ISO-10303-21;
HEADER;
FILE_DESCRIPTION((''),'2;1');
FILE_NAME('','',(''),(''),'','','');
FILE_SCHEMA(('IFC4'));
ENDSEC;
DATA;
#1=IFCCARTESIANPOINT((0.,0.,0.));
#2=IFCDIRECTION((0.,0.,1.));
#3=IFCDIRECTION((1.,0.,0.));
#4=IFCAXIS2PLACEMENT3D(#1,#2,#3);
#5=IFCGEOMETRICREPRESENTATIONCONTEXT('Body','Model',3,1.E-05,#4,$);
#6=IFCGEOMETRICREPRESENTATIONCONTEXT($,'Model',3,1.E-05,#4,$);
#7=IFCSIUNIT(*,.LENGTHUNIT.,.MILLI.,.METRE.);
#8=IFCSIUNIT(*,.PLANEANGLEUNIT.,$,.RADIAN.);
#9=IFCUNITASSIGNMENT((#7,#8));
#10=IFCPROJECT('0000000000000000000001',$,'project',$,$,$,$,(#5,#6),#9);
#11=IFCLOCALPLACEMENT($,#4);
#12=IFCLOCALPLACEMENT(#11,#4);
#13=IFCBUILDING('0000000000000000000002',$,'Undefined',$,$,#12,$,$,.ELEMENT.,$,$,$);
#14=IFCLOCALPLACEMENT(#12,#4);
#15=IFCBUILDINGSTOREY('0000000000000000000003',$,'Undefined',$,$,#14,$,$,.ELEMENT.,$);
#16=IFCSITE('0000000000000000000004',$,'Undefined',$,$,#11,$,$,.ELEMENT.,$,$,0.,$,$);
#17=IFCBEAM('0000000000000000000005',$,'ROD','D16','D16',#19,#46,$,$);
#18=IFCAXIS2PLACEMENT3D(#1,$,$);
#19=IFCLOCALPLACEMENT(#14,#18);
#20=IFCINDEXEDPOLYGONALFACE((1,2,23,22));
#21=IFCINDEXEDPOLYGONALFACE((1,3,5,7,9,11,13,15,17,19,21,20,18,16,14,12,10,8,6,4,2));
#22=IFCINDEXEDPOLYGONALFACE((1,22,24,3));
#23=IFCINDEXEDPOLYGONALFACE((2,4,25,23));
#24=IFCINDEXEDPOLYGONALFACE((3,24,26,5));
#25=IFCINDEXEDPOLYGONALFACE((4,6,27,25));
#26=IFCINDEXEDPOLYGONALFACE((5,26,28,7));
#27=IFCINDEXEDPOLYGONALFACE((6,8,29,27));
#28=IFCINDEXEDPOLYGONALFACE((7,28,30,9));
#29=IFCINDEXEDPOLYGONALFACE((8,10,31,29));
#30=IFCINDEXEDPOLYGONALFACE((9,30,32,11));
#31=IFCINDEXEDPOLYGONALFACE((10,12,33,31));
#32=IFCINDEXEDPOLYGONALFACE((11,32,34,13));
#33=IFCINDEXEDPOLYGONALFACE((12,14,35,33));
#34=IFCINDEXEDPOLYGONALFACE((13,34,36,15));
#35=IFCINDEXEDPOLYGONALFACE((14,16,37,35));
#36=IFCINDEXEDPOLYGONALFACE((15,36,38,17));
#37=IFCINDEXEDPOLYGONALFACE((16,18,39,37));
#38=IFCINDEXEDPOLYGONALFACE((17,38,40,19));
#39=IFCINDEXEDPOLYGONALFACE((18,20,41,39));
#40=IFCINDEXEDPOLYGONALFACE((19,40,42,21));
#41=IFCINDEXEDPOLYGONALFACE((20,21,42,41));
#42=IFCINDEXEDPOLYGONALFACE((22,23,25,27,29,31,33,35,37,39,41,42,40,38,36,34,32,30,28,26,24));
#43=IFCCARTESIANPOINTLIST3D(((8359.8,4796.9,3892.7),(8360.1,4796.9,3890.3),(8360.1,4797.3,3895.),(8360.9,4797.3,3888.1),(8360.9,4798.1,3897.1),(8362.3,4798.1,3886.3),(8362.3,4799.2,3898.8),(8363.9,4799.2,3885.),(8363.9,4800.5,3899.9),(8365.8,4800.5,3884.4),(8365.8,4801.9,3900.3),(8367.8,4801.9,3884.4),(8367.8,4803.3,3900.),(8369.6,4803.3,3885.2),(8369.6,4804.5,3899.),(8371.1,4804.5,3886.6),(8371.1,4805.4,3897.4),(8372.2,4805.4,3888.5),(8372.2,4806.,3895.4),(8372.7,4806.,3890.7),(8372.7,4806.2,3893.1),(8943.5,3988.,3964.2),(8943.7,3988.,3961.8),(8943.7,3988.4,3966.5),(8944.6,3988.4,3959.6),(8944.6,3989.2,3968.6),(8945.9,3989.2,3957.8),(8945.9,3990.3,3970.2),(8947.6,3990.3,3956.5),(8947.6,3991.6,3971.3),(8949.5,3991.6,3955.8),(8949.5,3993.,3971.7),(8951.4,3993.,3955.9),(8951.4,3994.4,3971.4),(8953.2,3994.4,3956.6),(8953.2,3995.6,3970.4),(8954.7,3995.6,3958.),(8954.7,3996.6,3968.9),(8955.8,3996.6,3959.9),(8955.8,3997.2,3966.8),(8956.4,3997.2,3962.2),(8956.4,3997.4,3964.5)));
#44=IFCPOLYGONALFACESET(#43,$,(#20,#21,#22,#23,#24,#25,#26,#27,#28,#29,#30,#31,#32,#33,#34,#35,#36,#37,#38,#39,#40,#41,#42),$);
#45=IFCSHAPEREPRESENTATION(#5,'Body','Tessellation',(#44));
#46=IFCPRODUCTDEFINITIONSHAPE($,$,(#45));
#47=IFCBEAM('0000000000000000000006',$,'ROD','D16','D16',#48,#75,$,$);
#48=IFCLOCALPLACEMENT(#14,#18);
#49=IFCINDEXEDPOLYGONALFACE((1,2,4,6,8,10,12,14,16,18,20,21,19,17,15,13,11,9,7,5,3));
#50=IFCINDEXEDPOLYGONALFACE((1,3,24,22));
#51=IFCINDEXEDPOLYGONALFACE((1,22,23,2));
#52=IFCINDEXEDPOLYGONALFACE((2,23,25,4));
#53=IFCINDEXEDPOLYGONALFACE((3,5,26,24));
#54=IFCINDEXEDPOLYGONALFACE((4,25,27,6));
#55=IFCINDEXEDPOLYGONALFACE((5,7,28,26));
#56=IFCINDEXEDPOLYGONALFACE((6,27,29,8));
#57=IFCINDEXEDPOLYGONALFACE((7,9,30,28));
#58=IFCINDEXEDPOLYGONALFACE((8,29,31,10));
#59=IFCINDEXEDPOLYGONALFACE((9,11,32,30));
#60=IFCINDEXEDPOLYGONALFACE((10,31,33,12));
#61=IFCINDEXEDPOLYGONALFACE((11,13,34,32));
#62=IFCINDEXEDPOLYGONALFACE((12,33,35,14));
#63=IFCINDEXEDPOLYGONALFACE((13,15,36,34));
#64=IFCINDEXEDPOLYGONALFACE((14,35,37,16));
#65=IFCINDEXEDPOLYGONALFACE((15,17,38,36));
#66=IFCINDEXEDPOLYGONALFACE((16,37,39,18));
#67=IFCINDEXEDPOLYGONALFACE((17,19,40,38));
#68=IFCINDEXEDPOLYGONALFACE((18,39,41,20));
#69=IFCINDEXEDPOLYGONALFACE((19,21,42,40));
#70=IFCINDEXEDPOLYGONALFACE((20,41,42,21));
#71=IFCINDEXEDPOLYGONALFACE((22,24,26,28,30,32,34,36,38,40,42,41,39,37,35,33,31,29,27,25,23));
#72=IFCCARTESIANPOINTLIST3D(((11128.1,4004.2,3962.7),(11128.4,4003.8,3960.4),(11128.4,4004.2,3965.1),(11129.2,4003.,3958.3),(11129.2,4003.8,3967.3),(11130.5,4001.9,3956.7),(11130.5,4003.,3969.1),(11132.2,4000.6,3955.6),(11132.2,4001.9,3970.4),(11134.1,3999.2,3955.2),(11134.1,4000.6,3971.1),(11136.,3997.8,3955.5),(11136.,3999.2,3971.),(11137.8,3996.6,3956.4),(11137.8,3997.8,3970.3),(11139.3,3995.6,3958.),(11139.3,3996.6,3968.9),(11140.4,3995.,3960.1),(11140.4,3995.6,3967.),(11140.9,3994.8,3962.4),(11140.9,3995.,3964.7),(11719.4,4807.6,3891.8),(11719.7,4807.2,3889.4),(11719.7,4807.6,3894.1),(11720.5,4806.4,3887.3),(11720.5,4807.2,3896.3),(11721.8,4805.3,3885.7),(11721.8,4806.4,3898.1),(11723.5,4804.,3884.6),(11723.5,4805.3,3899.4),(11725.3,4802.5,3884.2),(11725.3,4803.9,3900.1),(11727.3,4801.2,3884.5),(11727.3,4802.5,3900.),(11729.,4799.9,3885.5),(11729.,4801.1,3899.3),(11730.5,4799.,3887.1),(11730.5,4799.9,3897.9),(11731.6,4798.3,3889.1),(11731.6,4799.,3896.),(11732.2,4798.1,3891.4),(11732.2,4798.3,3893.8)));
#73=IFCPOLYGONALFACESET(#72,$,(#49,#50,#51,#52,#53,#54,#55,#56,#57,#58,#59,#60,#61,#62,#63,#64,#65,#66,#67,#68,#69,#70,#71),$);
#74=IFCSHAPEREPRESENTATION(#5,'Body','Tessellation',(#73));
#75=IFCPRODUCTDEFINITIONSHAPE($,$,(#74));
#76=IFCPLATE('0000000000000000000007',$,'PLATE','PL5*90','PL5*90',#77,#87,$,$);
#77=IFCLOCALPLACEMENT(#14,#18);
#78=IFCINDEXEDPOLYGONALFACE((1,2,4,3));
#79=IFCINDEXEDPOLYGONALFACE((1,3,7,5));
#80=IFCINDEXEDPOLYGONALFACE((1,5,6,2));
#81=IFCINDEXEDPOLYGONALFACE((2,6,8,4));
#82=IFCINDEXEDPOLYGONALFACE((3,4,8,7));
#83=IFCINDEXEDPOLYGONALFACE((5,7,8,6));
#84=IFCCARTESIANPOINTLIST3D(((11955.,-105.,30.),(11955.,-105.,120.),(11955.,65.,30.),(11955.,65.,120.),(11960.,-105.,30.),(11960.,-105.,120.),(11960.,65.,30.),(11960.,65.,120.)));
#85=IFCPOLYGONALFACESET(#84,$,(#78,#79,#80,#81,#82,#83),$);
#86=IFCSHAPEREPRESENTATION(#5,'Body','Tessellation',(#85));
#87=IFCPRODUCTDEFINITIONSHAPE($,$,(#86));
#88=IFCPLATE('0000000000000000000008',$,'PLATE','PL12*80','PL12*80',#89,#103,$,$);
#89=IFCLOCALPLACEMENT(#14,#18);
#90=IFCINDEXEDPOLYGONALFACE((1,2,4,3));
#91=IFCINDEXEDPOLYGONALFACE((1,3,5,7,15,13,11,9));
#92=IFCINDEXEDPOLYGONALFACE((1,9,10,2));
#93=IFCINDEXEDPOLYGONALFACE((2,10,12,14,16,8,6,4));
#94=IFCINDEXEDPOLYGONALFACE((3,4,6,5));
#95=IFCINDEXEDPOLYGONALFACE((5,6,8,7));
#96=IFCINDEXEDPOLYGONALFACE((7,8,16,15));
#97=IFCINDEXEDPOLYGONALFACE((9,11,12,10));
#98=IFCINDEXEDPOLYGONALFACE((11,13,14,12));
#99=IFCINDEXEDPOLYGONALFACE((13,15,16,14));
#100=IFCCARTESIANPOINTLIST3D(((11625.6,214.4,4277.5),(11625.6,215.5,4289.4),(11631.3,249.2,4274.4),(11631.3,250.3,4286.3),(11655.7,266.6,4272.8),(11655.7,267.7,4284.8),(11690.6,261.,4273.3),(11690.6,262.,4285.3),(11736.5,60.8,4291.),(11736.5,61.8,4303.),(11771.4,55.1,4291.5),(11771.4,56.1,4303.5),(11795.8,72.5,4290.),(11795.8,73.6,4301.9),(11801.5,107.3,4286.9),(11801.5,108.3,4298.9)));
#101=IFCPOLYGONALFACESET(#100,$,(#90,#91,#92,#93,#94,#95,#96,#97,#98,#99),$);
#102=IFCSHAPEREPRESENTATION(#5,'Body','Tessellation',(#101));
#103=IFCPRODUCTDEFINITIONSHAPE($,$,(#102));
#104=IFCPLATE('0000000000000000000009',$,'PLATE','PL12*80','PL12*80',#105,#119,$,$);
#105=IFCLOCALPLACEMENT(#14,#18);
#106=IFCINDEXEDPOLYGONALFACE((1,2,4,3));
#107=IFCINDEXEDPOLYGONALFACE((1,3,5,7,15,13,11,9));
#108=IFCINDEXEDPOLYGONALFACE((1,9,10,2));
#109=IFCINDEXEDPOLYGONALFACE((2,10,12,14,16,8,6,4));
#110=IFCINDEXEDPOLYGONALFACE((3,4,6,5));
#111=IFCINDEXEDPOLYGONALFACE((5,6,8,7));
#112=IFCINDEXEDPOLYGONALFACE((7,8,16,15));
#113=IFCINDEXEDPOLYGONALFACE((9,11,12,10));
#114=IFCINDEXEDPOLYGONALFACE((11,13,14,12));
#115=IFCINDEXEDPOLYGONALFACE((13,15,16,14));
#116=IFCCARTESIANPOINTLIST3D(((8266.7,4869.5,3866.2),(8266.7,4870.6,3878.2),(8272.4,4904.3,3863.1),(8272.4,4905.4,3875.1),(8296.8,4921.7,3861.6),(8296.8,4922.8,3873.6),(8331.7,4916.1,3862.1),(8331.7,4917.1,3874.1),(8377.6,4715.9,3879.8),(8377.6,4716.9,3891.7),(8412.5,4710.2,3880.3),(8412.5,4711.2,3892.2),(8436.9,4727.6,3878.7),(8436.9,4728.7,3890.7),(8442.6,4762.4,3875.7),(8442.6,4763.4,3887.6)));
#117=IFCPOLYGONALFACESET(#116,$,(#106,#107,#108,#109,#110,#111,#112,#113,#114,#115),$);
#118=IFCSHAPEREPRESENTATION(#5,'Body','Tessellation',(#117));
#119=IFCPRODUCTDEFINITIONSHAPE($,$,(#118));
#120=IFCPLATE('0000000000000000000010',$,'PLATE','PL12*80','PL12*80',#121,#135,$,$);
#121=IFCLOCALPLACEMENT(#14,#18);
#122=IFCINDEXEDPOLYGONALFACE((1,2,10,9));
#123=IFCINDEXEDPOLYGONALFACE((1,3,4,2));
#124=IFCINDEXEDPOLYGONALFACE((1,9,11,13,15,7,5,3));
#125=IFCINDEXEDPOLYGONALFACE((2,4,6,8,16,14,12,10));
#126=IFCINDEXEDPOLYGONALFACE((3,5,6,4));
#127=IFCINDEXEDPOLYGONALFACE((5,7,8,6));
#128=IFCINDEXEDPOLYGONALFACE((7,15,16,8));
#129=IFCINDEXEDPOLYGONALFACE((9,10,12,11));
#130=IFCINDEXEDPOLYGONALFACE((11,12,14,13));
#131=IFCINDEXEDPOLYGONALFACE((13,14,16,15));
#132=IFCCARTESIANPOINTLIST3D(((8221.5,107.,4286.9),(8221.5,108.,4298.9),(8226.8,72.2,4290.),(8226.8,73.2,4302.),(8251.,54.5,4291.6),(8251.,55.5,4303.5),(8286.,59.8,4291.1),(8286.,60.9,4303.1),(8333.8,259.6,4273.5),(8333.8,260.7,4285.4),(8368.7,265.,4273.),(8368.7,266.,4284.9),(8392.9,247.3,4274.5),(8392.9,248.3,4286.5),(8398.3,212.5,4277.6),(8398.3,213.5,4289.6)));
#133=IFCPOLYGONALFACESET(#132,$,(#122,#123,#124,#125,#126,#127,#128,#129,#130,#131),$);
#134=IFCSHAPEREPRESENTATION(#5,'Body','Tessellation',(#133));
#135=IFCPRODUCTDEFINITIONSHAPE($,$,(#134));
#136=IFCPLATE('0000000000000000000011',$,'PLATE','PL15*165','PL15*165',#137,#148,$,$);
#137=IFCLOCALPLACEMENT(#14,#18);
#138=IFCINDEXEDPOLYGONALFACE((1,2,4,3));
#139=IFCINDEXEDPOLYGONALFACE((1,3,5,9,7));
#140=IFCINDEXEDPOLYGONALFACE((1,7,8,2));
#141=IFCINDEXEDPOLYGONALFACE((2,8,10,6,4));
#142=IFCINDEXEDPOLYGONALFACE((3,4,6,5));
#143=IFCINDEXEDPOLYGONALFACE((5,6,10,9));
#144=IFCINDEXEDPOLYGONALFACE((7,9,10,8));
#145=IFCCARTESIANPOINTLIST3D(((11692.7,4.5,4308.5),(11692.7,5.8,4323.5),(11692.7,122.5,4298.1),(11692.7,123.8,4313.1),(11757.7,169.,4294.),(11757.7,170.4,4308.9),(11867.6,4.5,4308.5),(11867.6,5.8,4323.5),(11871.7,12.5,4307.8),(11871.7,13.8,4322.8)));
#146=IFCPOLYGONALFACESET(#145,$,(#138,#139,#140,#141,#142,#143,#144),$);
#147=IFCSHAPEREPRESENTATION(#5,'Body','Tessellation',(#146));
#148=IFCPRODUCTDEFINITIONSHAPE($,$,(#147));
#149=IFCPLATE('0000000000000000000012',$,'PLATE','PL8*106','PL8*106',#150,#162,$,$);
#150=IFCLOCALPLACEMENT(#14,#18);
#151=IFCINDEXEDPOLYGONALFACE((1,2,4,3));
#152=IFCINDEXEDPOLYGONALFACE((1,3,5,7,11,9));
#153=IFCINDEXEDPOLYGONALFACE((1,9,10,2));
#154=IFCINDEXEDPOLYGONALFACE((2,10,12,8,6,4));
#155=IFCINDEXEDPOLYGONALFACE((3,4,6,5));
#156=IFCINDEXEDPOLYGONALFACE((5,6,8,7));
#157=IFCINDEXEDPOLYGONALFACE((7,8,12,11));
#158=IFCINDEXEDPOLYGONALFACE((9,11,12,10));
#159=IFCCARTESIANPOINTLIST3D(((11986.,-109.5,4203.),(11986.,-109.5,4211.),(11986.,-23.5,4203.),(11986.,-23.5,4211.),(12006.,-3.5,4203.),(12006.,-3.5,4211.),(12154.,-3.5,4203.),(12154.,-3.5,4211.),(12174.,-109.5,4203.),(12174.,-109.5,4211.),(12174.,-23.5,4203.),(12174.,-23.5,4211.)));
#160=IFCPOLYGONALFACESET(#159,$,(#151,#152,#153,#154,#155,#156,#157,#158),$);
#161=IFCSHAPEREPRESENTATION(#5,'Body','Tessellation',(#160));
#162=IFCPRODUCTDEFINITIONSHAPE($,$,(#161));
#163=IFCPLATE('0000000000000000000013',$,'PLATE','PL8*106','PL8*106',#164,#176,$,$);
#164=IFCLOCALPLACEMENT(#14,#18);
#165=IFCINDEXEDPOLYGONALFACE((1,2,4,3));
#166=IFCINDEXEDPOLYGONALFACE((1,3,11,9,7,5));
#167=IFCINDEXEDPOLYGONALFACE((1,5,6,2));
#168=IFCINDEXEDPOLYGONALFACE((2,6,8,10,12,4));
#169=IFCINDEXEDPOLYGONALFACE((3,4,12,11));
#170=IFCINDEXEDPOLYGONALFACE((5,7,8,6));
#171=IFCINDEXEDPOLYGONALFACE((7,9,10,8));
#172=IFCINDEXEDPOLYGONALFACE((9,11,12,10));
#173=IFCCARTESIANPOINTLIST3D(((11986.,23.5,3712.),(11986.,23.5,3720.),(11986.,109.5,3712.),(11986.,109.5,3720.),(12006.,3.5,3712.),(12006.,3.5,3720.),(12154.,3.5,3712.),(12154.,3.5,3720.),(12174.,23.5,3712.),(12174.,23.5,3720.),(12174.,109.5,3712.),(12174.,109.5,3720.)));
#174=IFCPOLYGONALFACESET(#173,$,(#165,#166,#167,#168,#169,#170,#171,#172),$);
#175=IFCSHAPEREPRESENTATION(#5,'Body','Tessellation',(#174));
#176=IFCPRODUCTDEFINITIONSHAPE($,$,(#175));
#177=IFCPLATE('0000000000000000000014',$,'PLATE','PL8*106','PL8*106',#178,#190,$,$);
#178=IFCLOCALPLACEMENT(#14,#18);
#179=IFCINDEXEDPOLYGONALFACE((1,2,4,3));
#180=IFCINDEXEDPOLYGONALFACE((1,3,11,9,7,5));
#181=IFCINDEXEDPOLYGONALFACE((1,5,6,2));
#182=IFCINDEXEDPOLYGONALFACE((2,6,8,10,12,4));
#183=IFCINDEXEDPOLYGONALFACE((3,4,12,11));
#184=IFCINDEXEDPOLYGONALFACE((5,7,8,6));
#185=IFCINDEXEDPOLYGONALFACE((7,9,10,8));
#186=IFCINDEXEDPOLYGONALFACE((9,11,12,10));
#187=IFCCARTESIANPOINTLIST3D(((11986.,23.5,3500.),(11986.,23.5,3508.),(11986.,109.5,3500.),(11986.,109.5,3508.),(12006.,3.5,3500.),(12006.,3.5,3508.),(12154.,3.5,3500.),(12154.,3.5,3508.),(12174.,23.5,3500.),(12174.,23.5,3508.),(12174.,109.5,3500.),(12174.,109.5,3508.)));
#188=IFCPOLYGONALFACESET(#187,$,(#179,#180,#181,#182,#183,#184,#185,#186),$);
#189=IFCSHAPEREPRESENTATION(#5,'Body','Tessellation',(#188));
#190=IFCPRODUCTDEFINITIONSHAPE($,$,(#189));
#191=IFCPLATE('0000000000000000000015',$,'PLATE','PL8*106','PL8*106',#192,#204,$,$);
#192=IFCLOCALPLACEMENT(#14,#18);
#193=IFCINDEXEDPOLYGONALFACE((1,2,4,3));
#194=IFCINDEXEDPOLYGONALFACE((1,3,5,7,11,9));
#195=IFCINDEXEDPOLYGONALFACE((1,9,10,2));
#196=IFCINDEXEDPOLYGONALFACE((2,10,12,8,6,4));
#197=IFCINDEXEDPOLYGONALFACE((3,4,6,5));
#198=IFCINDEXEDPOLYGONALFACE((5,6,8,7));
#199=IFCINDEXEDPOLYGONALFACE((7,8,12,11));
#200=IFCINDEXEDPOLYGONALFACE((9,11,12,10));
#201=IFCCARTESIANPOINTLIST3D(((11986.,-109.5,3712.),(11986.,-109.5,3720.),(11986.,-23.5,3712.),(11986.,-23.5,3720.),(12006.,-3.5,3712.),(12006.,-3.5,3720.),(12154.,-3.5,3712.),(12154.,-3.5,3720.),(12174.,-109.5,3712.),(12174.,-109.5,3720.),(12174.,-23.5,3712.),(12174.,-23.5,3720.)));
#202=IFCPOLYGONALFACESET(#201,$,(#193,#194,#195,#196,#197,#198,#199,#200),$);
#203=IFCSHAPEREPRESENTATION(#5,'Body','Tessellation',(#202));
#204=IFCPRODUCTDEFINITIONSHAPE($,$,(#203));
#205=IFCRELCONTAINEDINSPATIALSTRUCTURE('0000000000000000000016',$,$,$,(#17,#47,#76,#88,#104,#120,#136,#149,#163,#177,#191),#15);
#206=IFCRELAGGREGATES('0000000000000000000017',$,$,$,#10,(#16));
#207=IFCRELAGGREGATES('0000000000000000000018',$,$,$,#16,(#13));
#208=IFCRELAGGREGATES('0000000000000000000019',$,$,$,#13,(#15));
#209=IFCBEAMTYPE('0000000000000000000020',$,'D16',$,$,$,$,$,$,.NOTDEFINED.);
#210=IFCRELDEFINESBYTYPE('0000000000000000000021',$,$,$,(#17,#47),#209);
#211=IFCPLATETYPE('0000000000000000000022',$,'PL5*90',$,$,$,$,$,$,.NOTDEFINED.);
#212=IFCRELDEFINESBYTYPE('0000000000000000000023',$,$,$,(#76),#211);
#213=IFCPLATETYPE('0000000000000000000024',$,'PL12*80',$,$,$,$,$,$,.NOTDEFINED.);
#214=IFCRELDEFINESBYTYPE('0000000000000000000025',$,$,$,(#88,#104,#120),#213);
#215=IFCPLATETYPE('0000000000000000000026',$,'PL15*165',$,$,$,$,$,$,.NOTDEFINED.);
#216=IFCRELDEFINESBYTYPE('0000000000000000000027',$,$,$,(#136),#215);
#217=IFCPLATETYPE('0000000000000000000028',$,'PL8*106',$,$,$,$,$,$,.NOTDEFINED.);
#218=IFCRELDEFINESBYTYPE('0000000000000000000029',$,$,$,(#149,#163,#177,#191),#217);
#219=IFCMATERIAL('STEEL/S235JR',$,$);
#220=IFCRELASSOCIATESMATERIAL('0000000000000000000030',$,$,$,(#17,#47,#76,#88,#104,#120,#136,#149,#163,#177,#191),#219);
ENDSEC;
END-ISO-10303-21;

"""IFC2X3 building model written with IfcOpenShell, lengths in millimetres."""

from ifc_helpers import new_model, si_unit, frame, origin_with_axes, origin_2d_with_axis, place, context, project, spatial, polyline, circle, outline, extrude, material, type_object, element, save


model = new_model("IFC2X3")

# Units and contexts
model_context_1 = context("Model", 3, precision=1e-05, world=origin_with_axes(), identifier="Body")
model_context_2 = context("Model", 3, precision=1e-05, world=origin_with_axes())
ifc_project = project(units=[si_unit("LENGTHUNIT", "METRE", prefix="MILLI"), si_unit("PLANEANGLEUNIT", "RADIAN")], contexts=[model_context_1, model_context_2])

# Site, building, storey
site_placement = place(None, origin_with_axes())
site = spatial("IfcSite", under=ifc_project, at=site_placement, Name="Undefined", CompositionType="ELEMENT", RefElevation=0.0)
building_placement = place(site_placement, origin_with_axes())
building = spatial("IfcBuilding", under=site, at=building_placement, Name="Undefined", CompositionType="ELEMENT")
storey_placement = place(building_placement, origin_with_axes())
storey = spatial("IfcBuildingStorey", under=building, at=storey_placement, Name="Undefined", CompositionType="ELEMENT")

# Shared definitions
ifc_material = material(Name="STEEL/S235JR")

# Beams
beam_type_1 = type_object("IfcBeamType", Name="D16", PredefinedType="NOTDEFINED")
beam_1_placement = place(storey_placement, frame((8366.3, 4801.5, 3892.3), z_axis=(0.0, 0.087999, 0.996121), x_axis=(0.583639, -0.808863, 0.071457)))
element("IfcBeam", 1, at=beam_1_placement, inside=storey, type_object=beam_type_1, material=ifc_material, Name="ROD", Description="D16", ObjectType="D16", context=model_context_1, shape_type="SweptSolid", body=[
    extrude(circle(Radius=8.0, at=origin_2d_with_axis()), frame((1000.0, 0.0, 0.0), z_axis=(-1.0, 0.0, 0.0), x_axis=(0.0, -1.0, 0.0)), (0.0, 0.0, 1.0), 1000.0),
])
beam_2_placement = place(storey_placement, frame((11725.8, 4802.9, 3892.2), z_axis=(0.0, 0.087999, 0.996121), x_axis=(-0.591248, -0.803361, 0.070971)))
element("IfcBeam", 2, at=beam_2_placement, inside=storey, type_object=beam_type_1, material=ifc_material, Name="ROD", Description="D16", ObjectType="D16", context=model_context_1, shape_type="SweptSolid", body=[
    extrude(circle(Radius=8.0, at=origin_2d_with_axis()), frame((1000.0, 0.0, 0.0), z_axis=(-1.0, 0.0, 0.0), x_axis=(0.0, -1.0, 0.0)), (0.0, 0.0, 1.0), 1000.0),
])

# Plates
plate_type_1 = type_object("IfcPlateType", Name="PL5*90", PredefinedType="NOTDEFINED")
plate_1_placement = place(storey_placement, frame((11957.5, 65.0, 120.0), z_axis=(1.0, 0.0, 0.0), x_axis=(0.0, -1.0, 0.0)))
element("IfcPlate", 3, at=plate_1_placement, inside=storey, type_object=plate_type_1, material=ifc_material, Name="PLATE", Description="PL5*90", ObjectType="PL5*90", context=model_context_1, shape_type="SweptSolid", body=[
    extrude(outline(polyline([(0.0, 0.0), (170.0, 0.0), (170.0, 90.0), (0.0, 90.0), (0.0, 0.0)])), frame((0.0, 0.0, -2.5), z_axis=(0.0, 0.0, 1.0), x_axis=(1.0, 0.0, 0.0)), (0.0, 0.0, 1.0), 5.0),
])
plate_type_2 = type_object("IfcPlateType", Name="PL12*80", PredefinedType="NOTDEFINED")
for number, where, z_axis, x_axis, name in (
    (4, (11611.0, 235.2, 4281.6), (0.000003, -0.088001, -0.99612), (0.812014, 0.581374, -0.05136), "PLATE"),
    (5, (8252.1, 4890.3, 3870.4), (0.000003, -0.088001, -0.99612), (0.812014, 0.581374, -0.05136), "PLATE"),
    (6, (8348.6, 280.2, 4277.7), (0.000003, -0.088001, -0.99612), (0.80649, -0.588954, 0.052029), "PLATE"),
):
    element("IfcPlate", number, at=place(storey_placement, frame(where, z_axis=z_axis, x_axis=x_axis)), inside=storey, type_object=plate_type_2, material=ifc_material, Name=name, Description="PL12*80", ObjectType="PL12*80", context=model_context_1, shape_type="SweptSolid", body=[
        extrude(outline(polyline([(0.0, 25.0), (25.0, 0.0), (55.0, 0.0), (80.0, 25.0), (80.0, 215.0), (55.0, 240.0), (25.0, 240.0), (0.0, 215.0), (0.0, 25.0)])), frame((0.0, 0.0, -6.0), z_axis=(0.0, 0.0, 1.0), x_axis=(1.0, 0.0, 0.0)), (0.0, 0.0, 1.0), 12.0),
    ])
plate_type_3 = type_object("IfcPlateType", Name="PL15*165", PredefinedType="NOTDEFINED")
plate_2_placement = place(storey_placement, frame((11692.7, 5.1, 4316.0), z_axis=(0.0, 0.087999, 0.996121), x_axis=(1.0, 0.0, 0.0)))
element("IfcPlate", 7, at=plate_2_placement, inside=storey, type_object=plate_type_3, material=ifc_material, Name="PLATE", Description="PL15*165", ObjectType="PL15*165", context=model_context_1, shape_type="SweptSolid", body=[
    extrude(outline(polyline([(0.0, 0.0), (174.8, 0.0), (179.0, 8.1), (65.0, 165.2), (0.0, 118.5), (0.0, 0.0)])), frame((0.0, 0.0, -7.5), z_axis=(0.0, 0.0, 1.0), x_axis=(1.0, 0.0, 0.0)), (0.0, 0.0, 1.0), 15.0),
])
plate_type_4 = type_object("IfcPlateType", Name="PL8*106", PredefinedType="NOTDEFINED")
for number, where, z_axis, x_axis, name in (
    (8, (11986.0, -109.5, 4207.0), (0.0, 0.0, -1.0), (0.0, 1.0, 0.0), "PLATE"),
    (9, (11986.0, 109.5, 3716.0), (0.0, 0.0, 1.0), (0.0, -1.0, 0.0), "PLATE"),
    (10, (11986.0, 109.5, 3504.0), (0.0, 0.0, 1.0), (0.0, -1.0, 0.0), "PLATE"),
    (11, (11986.0, -109.5, 3716.0), (0.0, 0.0, -1.0), (0.0, 1.0, 0.0), "PLATE"),
):
    element("IfcPlate", number, at=place(storey_placement, frame(where, z_axis=z_axis, x_axis=x_axis)), inside=storey, type_object=plate_type_4, material=ifc_material, Name=name, Description="PL8*106", ObjectType="PL8*106", context=model_context_1, shape_type="SweptSolid", body=[
        extrude(outline(polyline([(0.0, 0.0), (86.0, 0.0), (106.0, 20.0), (106.0, 168.0), (86.0, 188.0), (0.0, 188.0), (0.0, 0.0)])), frame((0.0, 0.0, -4.0), z_axis=(0.0, 0.0, 1.0), x_axis=(1.0, 0.0, 0.0)), (0.0, 0.0, 1.0), 8.0),
    ])

save(model, "model.ifc")
